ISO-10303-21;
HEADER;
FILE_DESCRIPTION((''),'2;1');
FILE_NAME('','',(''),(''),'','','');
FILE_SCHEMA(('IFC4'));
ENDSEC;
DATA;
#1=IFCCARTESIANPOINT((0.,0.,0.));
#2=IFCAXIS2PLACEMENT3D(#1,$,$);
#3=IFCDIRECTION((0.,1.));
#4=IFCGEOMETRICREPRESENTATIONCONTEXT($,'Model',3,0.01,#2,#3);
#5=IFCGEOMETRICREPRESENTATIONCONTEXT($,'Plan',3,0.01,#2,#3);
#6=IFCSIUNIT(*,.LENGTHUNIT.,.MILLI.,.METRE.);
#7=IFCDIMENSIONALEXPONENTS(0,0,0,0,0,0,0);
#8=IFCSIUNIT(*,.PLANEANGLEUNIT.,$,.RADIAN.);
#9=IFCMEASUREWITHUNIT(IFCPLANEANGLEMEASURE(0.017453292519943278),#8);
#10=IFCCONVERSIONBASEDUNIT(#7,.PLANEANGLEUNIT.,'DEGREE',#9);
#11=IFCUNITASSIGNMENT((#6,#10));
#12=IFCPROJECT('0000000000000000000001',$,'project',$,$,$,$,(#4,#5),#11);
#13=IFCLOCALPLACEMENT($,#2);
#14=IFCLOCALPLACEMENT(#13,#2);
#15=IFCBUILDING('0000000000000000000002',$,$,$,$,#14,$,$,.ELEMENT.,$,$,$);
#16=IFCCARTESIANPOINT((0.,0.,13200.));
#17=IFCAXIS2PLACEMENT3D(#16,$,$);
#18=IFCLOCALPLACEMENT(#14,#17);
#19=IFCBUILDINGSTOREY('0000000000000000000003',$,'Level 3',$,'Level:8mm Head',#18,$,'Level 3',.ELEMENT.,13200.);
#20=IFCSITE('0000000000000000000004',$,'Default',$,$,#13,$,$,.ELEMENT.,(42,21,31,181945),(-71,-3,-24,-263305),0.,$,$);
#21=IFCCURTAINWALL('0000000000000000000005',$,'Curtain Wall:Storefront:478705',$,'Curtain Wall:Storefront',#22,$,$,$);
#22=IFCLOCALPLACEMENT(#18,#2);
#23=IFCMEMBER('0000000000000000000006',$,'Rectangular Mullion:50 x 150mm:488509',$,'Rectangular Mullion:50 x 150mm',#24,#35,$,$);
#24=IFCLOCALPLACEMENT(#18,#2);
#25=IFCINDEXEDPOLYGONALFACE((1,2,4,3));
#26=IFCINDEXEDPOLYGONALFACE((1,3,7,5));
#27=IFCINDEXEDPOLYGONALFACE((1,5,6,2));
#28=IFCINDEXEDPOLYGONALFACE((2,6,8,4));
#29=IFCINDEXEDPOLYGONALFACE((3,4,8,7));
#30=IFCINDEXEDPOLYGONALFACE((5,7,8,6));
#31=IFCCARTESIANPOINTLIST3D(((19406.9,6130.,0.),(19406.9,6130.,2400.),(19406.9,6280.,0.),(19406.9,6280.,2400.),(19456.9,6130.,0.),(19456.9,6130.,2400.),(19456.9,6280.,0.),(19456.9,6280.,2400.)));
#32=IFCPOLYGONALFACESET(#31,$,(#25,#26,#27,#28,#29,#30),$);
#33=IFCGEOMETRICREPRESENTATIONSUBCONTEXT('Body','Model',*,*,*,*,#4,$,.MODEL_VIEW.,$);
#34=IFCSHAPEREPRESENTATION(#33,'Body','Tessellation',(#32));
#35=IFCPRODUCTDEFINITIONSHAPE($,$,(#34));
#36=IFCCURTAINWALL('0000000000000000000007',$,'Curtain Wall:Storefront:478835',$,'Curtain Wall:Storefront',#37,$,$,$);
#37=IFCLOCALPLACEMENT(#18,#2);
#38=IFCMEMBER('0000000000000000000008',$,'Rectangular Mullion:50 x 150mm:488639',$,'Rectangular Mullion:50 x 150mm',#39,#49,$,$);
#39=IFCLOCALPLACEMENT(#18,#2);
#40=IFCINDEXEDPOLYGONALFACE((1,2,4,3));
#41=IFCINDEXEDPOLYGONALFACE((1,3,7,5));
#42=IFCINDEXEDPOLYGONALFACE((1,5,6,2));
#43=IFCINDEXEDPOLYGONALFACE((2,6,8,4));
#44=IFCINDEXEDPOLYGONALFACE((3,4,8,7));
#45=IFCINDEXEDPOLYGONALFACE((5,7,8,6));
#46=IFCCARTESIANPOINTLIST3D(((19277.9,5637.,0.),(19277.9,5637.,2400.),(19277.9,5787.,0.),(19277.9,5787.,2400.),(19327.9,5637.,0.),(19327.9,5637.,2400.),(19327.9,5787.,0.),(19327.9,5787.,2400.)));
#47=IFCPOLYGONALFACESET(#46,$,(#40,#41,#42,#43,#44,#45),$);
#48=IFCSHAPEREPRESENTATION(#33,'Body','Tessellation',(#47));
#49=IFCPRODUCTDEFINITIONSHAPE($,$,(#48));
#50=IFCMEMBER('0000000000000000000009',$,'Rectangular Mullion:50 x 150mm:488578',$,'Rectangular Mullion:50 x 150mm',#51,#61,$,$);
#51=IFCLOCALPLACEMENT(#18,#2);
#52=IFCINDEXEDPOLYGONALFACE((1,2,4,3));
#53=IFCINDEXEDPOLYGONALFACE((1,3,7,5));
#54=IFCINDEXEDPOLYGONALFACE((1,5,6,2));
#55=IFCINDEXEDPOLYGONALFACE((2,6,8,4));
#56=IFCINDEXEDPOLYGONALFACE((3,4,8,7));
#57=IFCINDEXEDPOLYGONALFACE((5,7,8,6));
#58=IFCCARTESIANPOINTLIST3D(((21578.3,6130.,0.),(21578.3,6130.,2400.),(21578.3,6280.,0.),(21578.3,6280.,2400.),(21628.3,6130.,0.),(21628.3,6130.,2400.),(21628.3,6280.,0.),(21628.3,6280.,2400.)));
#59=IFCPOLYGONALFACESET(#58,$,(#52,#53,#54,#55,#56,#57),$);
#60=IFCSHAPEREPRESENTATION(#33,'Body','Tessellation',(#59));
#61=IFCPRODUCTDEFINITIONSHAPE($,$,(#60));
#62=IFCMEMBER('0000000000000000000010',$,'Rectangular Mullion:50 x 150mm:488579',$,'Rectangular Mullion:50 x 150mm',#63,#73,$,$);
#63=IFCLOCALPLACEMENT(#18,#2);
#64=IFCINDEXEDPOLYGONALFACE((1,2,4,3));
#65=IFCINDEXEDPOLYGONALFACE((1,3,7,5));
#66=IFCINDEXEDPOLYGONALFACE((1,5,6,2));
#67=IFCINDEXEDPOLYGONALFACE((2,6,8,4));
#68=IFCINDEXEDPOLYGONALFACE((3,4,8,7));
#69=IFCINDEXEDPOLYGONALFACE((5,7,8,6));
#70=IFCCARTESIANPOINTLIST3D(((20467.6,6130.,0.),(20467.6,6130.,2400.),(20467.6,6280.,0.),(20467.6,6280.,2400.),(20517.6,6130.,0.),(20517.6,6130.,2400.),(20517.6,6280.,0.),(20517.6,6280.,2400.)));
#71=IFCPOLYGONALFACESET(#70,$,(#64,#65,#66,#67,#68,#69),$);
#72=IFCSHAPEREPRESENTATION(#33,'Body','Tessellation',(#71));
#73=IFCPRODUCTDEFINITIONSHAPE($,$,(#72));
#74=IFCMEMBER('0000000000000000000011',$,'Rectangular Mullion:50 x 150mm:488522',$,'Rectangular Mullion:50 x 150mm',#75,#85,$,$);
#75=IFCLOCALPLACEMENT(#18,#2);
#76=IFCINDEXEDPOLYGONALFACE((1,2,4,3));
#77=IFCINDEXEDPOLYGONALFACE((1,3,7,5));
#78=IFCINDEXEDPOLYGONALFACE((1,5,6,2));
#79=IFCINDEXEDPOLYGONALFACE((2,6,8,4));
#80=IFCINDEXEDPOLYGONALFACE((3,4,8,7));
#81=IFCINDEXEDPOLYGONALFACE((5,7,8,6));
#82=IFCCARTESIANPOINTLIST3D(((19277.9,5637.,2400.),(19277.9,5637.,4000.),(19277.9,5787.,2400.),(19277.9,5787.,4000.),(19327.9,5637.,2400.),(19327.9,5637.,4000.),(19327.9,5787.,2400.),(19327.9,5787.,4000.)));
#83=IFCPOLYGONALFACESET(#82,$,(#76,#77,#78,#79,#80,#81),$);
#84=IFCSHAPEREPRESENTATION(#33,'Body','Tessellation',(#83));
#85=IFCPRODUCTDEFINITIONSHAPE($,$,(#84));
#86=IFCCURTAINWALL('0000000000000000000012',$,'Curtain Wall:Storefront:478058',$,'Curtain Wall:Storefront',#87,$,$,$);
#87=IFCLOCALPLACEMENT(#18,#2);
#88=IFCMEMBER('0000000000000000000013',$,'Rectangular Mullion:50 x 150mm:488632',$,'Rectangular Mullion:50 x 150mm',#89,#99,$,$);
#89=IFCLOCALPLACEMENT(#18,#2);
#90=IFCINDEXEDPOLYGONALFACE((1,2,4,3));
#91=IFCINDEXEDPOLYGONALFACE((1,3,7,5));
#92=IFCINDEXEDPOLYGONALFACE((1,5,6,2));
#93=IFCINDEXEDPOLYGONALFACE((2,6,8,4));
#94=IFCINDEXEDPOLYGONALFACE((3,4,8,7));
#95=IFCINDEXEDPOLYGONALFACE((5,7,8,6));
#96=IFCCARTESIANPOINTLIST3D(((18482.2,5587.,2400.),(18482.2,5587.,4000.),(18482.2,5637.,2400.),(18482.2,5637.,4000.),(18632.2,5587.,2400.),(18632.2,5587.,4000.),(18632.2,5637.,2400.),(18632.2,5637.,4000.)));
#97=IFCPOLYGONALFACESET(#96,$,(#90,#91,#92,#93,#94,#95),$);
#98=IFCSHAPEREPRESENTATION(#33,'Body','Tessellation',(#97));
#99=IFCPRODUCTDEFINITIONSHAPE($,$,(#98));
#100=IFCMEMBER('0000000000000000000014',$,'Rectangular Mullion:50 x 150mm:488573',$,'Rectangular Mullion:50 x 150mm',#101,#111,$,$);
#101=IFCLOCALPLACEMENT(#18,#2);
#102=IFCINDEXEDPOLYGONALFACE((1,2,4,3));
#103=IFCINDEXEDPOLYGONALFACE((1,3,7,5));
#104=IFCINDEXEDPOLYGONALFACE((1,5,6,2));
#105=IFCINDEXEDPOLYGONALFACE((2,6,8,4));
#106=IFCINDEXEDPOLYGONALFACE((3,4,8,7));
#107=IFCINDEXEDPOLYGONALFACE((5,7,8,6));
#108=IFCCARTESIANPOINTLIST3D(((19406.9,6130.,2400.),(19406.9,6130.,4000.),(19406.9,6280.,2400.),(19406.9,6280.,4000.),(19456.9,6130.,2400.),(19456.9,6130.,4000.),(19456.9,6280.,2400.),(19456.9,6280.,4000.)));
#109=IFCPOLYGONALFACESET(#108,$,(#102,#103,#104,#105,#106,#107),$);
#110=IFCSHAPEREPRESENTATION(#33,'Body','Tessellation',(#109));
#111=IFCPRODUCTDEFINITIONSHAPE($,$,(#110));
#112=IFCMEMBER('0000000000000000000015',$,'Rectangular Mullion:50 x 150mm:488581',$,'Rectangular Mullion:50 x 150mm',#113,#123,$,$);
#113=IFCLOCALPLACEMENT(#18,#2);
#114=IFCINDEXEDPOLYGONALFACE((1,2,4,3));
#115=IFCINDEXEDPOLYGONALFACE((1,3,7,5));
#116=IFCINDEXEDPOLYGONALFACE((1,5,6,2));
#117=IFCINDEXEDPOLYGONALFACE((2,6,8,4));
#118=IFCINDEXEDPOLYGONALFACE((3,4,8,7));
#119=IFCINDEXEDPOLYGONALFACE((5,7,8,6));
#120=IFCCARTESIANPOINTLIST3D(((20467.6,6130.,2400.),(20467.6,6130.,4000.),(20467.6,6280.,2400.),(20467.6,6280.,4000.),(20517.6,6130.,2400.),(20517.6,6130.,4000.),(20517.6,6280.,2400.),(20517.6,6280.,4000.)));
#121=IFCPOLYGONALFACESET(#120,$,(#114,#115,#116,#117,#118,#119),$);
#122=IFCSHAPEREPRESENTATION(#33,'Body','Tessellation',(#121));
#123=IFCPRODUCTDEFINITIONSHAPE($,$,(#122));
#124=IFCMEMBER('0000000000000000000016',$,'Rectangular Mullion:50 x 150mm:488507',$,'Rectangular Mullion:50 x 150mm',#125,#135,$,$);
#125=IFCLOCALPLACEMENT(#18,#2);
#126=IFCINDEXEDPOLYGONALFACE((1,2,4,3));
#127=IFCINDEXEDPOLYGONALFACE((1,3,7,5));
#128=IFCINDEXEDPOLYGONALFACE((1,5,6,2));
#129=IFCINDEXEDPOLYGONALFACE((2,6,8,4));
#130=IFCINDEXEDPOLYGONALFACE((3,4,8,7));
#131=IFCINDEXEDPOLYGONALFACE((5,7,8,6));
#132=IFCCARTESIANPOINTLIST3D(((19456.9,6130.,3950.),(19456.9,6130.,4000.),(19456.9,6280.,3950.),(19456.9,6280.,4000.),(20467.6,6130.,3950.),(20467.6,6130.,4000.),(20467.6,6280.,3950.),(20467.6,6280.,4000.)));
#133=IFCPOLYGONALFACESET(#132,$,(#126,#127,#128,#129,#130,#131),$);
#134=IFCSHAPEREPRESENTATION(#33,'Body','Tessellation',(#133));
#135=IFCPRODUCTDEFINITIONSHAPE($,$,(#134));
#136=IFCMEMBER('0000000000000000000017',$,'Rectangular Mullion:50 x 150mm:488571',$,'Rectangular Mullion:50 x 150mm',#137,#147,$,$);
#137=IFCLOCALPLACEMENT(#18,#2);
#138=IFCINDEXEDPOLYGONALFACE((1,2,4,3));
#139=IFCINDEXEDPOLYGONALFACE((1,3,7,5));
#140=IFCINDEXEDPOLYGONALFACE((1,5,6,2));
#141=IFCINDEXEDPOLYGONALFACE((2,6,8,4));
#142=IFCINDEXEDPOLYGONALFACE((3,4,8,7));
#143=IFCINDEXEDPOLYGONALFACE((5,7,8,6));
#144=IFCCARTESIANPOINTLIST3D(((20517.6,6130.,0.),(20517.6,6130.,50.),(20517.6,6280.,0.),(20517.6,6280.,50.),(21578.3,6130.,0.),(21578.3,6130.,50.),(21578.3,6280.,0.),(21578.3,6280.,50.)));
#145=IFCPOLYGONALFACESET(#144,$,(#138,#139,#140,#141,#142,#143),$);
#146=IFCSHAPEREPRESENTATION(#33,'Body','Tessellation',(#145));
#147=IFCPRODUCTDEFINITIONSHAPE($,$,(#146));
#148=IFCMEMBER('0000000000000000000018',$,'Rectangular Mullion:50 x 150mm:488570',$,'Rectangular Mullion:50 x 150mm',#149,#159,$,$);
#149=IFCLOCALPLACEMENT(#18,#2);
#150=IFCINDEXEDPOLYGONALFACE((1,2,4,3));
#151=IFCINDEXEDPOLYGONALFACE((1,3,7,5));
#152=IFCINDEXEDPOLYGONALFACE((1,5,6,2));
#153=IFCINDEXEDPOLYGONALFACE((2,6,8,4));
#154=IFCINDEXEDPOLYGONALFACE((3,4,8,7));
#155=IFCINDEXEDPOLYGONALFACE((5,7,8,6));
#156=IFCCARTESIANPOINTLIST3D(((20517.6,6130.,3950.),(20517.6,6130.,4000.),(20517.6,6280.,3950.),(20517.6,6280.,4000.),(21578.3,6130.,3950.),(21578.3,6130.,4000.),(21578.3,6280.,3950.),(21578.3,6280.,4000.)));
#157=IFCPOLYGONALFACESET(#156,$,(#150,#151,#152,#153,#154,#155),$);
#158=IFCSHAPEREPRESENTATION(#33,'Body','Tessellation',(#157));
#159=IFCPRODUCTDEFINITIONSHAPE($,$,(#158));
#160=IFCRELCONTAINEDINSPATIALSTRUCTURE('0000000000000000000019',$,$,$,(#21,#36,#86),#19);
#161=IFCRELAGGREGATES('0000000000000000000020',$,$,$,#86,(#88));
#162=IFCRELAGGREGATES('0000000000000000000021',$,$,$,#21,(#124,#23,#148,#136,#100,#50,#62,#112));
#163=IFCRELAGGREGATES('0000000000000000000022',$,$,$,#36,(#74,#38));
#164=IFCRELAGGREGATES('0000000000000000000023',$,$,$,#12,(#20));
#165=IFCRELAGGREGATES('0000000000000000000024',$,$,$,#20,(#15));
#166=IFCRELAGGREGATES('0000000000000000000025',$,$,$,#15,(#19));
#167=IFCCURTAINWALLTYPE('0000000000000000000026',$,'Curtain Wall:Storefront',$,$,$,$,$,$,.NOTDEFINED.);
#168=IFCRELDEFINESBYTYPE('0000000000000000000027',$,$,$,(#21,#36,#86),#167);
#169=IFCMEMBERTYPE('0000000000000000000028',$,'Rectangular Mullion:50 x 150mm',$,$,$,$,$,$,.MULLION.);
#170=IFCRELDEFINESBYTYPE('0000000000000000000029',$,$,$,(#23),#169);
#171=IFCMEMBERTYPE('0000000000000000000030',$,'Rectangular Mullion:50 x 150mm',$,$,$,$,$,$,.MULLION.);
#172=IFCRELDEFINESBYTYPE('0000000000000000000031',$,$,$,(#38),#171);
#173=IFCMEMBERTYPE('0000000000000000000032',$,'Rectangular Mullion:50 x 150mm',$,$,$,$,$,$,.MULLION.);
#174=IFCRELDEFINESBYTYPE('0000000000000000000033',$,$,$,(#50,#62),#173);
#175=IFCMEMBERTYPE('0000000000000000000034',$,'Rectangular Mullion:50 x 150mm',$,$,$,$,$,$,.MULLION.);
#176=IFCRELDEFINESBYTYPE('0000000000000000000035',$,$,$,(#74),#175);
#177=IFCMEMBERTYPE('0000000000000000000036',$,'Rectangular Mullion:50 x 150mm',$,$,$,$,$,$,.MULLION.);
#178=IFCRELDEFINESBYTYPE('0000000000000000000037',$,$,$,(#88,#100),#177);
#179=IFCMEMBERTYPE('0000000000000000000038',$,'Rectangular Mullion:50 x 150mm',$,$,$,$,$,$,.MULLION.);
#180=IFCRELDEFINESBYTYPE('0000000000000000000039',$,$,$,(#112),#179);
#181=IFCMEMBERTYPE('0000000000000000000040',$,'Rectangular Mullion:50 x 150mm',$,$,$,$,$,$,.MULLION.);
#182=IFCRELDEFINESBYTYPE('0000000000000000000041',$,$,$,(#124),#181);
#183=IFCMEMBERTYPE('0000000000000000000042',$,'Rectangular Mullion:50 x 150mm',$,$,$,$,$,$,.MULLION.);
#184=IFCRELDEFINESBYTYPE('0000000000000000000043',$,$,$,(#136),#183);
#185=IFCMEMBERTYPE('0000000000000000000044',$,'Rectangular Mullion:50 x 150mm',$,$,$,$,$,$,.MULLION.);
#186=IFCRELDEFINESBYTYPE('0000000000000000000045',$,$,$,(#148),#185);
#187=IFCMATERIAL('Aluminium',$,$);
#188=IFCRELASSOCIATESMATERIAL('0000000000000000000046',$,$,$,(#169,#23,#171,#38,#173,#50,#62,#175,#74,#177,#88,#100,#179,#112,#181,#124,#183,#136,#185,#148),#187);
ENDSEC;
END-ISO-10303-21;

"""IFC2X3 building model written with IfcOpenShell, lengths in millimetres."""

from ifc_helpers import new_model, entity, si_unit, converted_unit, direction, frame, origin, origin_2d_with_axis, place, context, subcontext, project, spatial, rectangle, extrude, source, transform, mapped, material, type_object, type_shapes, element, aggregate, save


model = new_model("IFC2X3")

# Units and contexts
model_context = context("Model", 3, precision=0.01, world=origin(), true_north=direction((0.0, 1.0)))
plan_context = context("Plan", 3, precision=0.01, world=origin(), true_north=direction((0.0, 1.0)))
body_context = subcontext(model_context, "Body", "Model", "MODEL_VIEW")
ifc_project = project(units=[si_unit("LENGTHUNIT", "METRE", prefix="MILLI"), converted_unit("PLANEANGLEUNIT", "DEGREE", entity("IfcPlaneAngleMeasure", 0.017453292519943278), si_unit("PLANEANGLEUNIT", "RADIAN"), dimensions=[0, 0, 0, 0, 0, 0, 0])], contexts=[model_context, plan_context])

# Site, building, storey
site_placement = place(None, origin())
site = spatial("IfcSite", under=ifc_project, at=site_placement, Name="Default", CompositionType="ELEMENT", RefLatitude=(42, 21, 31, 181945), RefLongitude=(-71, -3, -24, -263305), RefElevation=0.0)
building_placement = place(site_placement, origin())
building = spatial("IfcBuilding", under=site, at=building_placement, CompositionType="ELEMENT")
storey_placement = place(building_placement, frame((0.0, 0.0, 13200.0)))
storey = spatial("IfcBuildingStorey", under=building, at=storey_placement, Name="Level 3", ObjectType="Level:8mm Head", LongName="Level 3", CompositionType="ELEMENT", Elevation=13200.0)

# Curtain walls, members
curtain_wall_type = type_object("IfcCurtainWallType", Name="Curtain Wall:Storefront", PredefinedType="NOTDEFINED")
curtain_wall_1_placement = place(storey_placement, frame((0.0, 0.0, -13200.0)))
curtain_wall_1 = element("IfcCurtainWall", 1, at=curtain_wall_1_placement, inside=storey, type_object=curtain_wall_type, Name="Curtain Wall:Storefront:478705", ObjectType="Curtain Wall:Storefront")
ifc_material_1 = material(Name="Aluminium")
member_type_1 = type_object("IfcMemberType", Name="Rectangular Mullion:50 x 150mm", PredefinedType="MULLION", material=ifc_material_1)
shared_shape_1 = source(origin(), body_context, "Body", "SweptSolid", [
    extrude(rectangle(XDim=50.0, YDim=150.0, at=origin_2d_with_axis()), frame((-25.0, 0.0, -2400.0), z_axis=(0.0, 0.0, 1.0), x_axis=(-1.0, 0.0, 0.0)), (0.0, 0.0, 1.0), 2400.0),
])
type_shapes(member_type_1, [shared_shape_1])
member_1_placement = place(curtain_wall_1_placement, frame((19406.9, 6205.0, 13200.0), z_axis=(0.0, 0.0, -1.0), x_axis=(-1.0, 0.0, 0.0)))
member_1 = element("IfcMember", 2, at=member_1_placement, type_object=member_type_1, material=ifc_material_1, Name="Rectangular Mullion:50 x 150mm:488509", ObjectType="Rectangular Mullion:50 x 150mm", context=body_context, shape_type="MappedRepresentation", body=[
    mapped(shared_shape_1, transform((0.0, 0.0, 0.0), scale=1.0)),
])
curtain_wall_2_placement = place(storey_placement, frame((0.0, 0.0, -13200.0)))
curtain_wall_2 = element("IfcCurtainWall", 3, at=curtain_wall_2_placement, inside=storey, type_object=curtain_wall_type, Name="Curtain Wall:Storefront:478835", ObjectType="Curtain Wall:Storefront")
member_type_2 = type_object("IfcMemberType", Name="Rectangular Mullion:50 x 150mm", PredefinedType="MULLION", material=ifc_material_1)
shared_shape_2 = source(origin(), body_context, "Body", "SweptSolid", [
    extrude(rectangle(XDim=50.0, YDim=150.0, at=origin_2d_with_axis()), frame((-25.0, 0.0, -2400.0), z_axis=(0.0, 0.0, 1.0), x_axis=(-1.0, 0.0, 0.0)), (0.0, 0.0, 1.0), 2400.0),
])
type_shapes(member_type_2, [shared_shape_2])
member_2_placement = place(curtain_wall_2_placement, frame((19327.9, 5712.0, 15600.0)))
member_2 = element("IfcMember", 4, at=member_2_placement, type_object=member_type_2, material=ifc_material_1, Name="Rectangular Mullion:50 x 150mm:488639", ObjectType="Rectangular Mullion:50 x 150mm", context=body_context, shape_type="MappedRepresentation", body=[
    mapped(shared_shape_2, transform((0.0, 0.0, 0.0), scale=1.0)),
])

# Members
member_type_3 = type_object("IfcMemberType", Name="Rectangular Mullion:50 x 150mm", PredefinedType="MULLION", material=ifc_material_1)
shared_shape_3 = source(origin(), body_context, "Body", "SweptSolid", [
    extrude(rectangle(XDim=50.0, YDim=150.0, at=origin_2d_with_axis()), frame((0.0, 0.0, -2400.0), z_axis=(0.0, 0.0, 1.0), x_axis=(-1.0, 0.0, 0.0)), (0.0, 0.0, 1.0), 2400.0),
])
type_shapes(member_type_3, [shared_shape_3])
member_3_placement = place(curtain_wall_1_placement, frame((21603.3, 6205.0, 13200.0), z_axis=(0.0, 0.0, -1.0), x_axis=(-1.0, 0.0, 0.0)))
member_3 = element("IfcMember", 5, at=member_3_placement, type_object=member_type_3, material=ifc_material_1, Name="Rectangular Mullion:50 x 150mm:488578", ObjectType="Rectangular Mullion:50 x 150mm", context=body_context, shape_type="MappedRepresentation", body=[
    mapped(shared_shape_3, transform((0.0, 0.0, 0.0), scale=1.0)),
])
member_4_placement = place(curtain_wall_1_placement, frame((20492.6, 6205.0, 13200.0), z_axis=(0.0, 0.0, -1.0), x_axis=(-1.0, 0.0, 0.0)))
member_4 = element("IfcMember", 6, at=member_4_placement, type_object=member_type_3, material=ifc_material_1, Name="Rectangular Mullion:50 x 150mm:488579", ObjectType="Rectangular Mullion:50 x 150mm", context=body_context, shape_type="MappedRepresentation", body=[
    mapped(shared_shape_3, transform((0.0, 0.0, 0.0), scale=1.0)),
])
member_type_4 = type_object("IfcMemberType", Name="Rectangular Mullion:50 x 150mm", PredefinedType="MULLION", material=ifc_material_1)
shared_shape_4 = source(origin(), body_context, "Body", "SweptSolid", [
    extrude(rectangle(XDim=50.0, YDim=150.0, at=origin_2d_with_axis()), frame((-25.0, 0.0, -1600.0), z_axis=(0.0, 0.0, 1.0), x_axis=(-1.0, 0.0, 0.0)), (0.0, 0.0, 1.0), 1600.0),
])
type_shapes(member_type_4, [shared_shape_4])
member_5_placement = place(curtain_wall_2_placement, frame((19327.9, 5712.0, 17200.0)))
member_5 = element("IfcMember", 7, at=member_5_placement, type_object=member_type_4, material=ifc_material_1, Name="Rectangular Mullion:50 x 150mm:488522", ObjectType="Rectangular Mullion:50 x 150mm", context=body_context, shape_type="MappedRepresentation", body=[
    mapped(shared_shape_4, transform((0.0, 0.0, 0.0), scale=1.0)),
])

# Curtain wall, member
curtain_wall_3_placement = place(storey_placement, frame((0.0, 0.0, -13200.0)))
curtain_wall_3 = element("IfcCurtainWall", 8, at=curtain_wall_3_placement, inside=storey, type_object=curtain_wall_type, Name="Curtain Wall:Storefront:478058", ObjectType="Curtain Wall:Storefront")
member_type_5 = type_object("IfcMemberType", Name="Rectangular Mullion:50 x 150mm", PredefinedType="MULLION", material=ifc_material_1)
shared_shape_5 = source(origin(), body_context, "Body", "SweptSolid", [
    extrude(rectangle(XDim=50.0, YDim=150.0, at=origin_2d_with_axis()), frame((-25.0, 0.0, -1600.0), z_axis=(0.0, 0.0, 1.0), x_axis=(-1.0, 0.0, 0.0)), (0.0, 0.0, 1.0), 1600.0),
])
type_shapes(member_type_5, [shared_shape_5])
member_6_placement = place(curtain_wall_3_placement, frame((18557.2, 5637.0, 15600.0), z_axis=(0.0, 0.0, -1.0), x_axis=(0.0, 1.0, 0.0)))
member_6 = element("IfcMember", 9, at=member_6_placement, type_object=member_type_5, material=ifc_material_1, Name="Rectangular Mullion:50 x 150mm:488632", ObjectType="Rectangular Mullion:50 x 150mm", context=body_context, shape_type="MappedRepresentation", body=[
    mapped(shared_shape_5, transform((0.0, 0.0, 0.0), scale=1.0)),
])
aggregate(curtain_wall_3, [member_6])

# Members
member_7_placement = place(curtain_wall_1_placement, frame((19406.9, 6205.0, 15600.0), z_axis=(0.0, 0.0, -1.0), x_axis=(-1.0, 0.0, 0.0)))
member_7 = element("IfcMember", 10, at=member_7_placement, type_object=member_type_5, material=ifc_material_1, Name="Rectangular Mullion:50 x 150mm:488573", ObjectType="Rectangular Mullion:50 x 150mm", context=body_context, shape_type="MappedRepresentation", body=[
    mapped(shared_shape_5, transform((0.0, 0.0, 0.0), scale=1.0)),
])
member_type_6 = type_object("IfcMemberType", Name="Rectangular Mullion:50 x 150mm", PredefinedType="MULLION", material=ifc_material_1)
shared_shape_6 = source(origin(), body_context, "Body", "SweptSolid", [
    extrude(rectangle(XDim=50.0, YDim=150.0, at=origin_2d_with_axis()), frame((0.0, 0.0, -1600.0), z_axis=(0.0, 0.0, 1.0), x_axis=(-1.0, 0.0, 0.0)), (0.0, 0.0, 1.0), 1600.0),
])
type_shapes(member_type_6, [shared_shape_6])
member_8_placement = place(curtain_wall_1_placement, frame((20492.6, 6205.0, 15600.0), z_axis=(0.0, 0.0, -1.0), x_axis=(-1.0, 0.0, 0.0)))
member_8 = element("IfcMember", 11, at=member_8_placement, type_object=member_type_6, material=ifc_material_1, Name="Rectangular Mullion:50 x 150mm:488581", ObjectType="Rectangular Mullion:50 x 150mm", context=body_context, shape_type="MappedRepresentation", body=[
    mapped(shared_shape_6, transform((0.0, 0.0, 0.0), scale=1.0)),
])
member_type_7 = type_object("IfcMemberType", Name="Rectangular Mullion:50 x 150mm", PredefinedType="MULLION", material=ifc_material_1)
shared_shape_7 = source(origin(), body_context, "Body", "SweptSolid", [
    extrude(rectangle(XDim=50.0, YDim=150.0, at=origin_2d_with_axis()), frame((-25.0, 0.0, -1010.7), z_axis=(0.0, 0.0, 1.0), x_axis=(-1.0, 0.0, 0.0)), (0.0, 0.0, 1.0), 1010.7),
])
type_shapes(member_type_7, [shared_shape_7])
member_9_placement = place(curtain_wall_1_placement, frame((19456.9, 6205.0, 17200.0), z_axis=(-1.0, 0.0, 0.0), x_axis=(0.0, 0.0, 1.0)))
member_9 = element("IfcMember", 12, at=member_9_placement, type_object=member_type_7, material=ifc_material_1, Name="Rectangular Mullion:50 x 150mm:488507", ObjectType="Rectangular Mullion:50 x 150mm", context=body_context, shape_type="MappedRepresentation", body=[
    mapped(shared_shape_7, transform((0.0, 0.0, 0.0), scale=1.0)),
])
member_type_8 = type_object("IfcMemberType", Name="Rectangular Mullion:50 x 150mm", PredefinedType="MULLION", material=ifc_material_1)
shared_shape_8 = source(origin(), body_context, "Body", "SweptSolid", [
    extrude(rectangle(XDim=50.0, YDim=150.0, at=origin_2d_with_axis()), frame((-25.0, 0.0, -1060.7), z_axis=(0.0, 0.0, 1.0), x_axis=(-1.0, 0.0, 0.0)), (0.0, 0.0, 1.0), 1060.7),
])
type_shapes(member_type_8, [shared_shape_8])
member_10_placement = place(curtain_wall_1_placement, frame((21578.3, 6205.0, 13200.0), z_axis=(1.0, 0.0, 0.0), x_axis=(0.0, 0.0, -1.0)))
member_10 = element("IfcMember", 13, at=member_10_placement, type_object=member_type_8, material=ifc_material_1, Name="Rectangular Mullion:50 x 150mm:488571", ObjectType="Rectangular Mullion:50 x 150mm", context=body_context, shape_type="MappedRepresentation", body=[
    mapped(shared_shape_8, transform((0.0, 0.0, 0.0), scale=1.0)),
])
member_type_9 = type_object("IfcMemberType", Name="Rectangular Mullion:50 x 150mm", PredefinedType="MULLION", material=ifc_material_1)
shared_shape_9 = source(origin(), body_context, "Body", "SweptSolid", [
    extrude(rectangle(XDim=50.0, YDim=150.0, at=origin_2d_with_axis()), frame((-25.0, 0.0, -1060.7), z_axis=(0.0, 0.0, 1.0), x_axis=(-1.0, 0.0, 0.0)), (0.0, 0.0, 1.0), 1060.7),
])
type_shapes(member_type_9, [shared_shape_9])
member_11_placement = place(curtain_wall_1_placement, frame((20517.6, 6205.0, 17200.0), z_axis=(-1.0, 0.0, 0.0), x_axis=(0.0, 0.0, 1.0)))
member_11 = element("IfcMember", 14, at=member_11_placement, type_object=member_type_9, material=ifc_material_1, Name="Rectangular Mullion:50 x 150mm:488570", ObjectType="Rectangular Mullion:50 x 150mm", context=body_context, shape_type="MappedRepresentation", body=[
    mapped(shared_shape_9, transform((0.0, 0.0, 0.0), scale=1.0)),
])

aggregate(curtain_wall_1, [member_9, member_1, member_11, member_10, member_7, member_3, member_4, member_8])
aggregate(curtain_wall_2, [member_5, member_2])

save(model, "model.ifc")
